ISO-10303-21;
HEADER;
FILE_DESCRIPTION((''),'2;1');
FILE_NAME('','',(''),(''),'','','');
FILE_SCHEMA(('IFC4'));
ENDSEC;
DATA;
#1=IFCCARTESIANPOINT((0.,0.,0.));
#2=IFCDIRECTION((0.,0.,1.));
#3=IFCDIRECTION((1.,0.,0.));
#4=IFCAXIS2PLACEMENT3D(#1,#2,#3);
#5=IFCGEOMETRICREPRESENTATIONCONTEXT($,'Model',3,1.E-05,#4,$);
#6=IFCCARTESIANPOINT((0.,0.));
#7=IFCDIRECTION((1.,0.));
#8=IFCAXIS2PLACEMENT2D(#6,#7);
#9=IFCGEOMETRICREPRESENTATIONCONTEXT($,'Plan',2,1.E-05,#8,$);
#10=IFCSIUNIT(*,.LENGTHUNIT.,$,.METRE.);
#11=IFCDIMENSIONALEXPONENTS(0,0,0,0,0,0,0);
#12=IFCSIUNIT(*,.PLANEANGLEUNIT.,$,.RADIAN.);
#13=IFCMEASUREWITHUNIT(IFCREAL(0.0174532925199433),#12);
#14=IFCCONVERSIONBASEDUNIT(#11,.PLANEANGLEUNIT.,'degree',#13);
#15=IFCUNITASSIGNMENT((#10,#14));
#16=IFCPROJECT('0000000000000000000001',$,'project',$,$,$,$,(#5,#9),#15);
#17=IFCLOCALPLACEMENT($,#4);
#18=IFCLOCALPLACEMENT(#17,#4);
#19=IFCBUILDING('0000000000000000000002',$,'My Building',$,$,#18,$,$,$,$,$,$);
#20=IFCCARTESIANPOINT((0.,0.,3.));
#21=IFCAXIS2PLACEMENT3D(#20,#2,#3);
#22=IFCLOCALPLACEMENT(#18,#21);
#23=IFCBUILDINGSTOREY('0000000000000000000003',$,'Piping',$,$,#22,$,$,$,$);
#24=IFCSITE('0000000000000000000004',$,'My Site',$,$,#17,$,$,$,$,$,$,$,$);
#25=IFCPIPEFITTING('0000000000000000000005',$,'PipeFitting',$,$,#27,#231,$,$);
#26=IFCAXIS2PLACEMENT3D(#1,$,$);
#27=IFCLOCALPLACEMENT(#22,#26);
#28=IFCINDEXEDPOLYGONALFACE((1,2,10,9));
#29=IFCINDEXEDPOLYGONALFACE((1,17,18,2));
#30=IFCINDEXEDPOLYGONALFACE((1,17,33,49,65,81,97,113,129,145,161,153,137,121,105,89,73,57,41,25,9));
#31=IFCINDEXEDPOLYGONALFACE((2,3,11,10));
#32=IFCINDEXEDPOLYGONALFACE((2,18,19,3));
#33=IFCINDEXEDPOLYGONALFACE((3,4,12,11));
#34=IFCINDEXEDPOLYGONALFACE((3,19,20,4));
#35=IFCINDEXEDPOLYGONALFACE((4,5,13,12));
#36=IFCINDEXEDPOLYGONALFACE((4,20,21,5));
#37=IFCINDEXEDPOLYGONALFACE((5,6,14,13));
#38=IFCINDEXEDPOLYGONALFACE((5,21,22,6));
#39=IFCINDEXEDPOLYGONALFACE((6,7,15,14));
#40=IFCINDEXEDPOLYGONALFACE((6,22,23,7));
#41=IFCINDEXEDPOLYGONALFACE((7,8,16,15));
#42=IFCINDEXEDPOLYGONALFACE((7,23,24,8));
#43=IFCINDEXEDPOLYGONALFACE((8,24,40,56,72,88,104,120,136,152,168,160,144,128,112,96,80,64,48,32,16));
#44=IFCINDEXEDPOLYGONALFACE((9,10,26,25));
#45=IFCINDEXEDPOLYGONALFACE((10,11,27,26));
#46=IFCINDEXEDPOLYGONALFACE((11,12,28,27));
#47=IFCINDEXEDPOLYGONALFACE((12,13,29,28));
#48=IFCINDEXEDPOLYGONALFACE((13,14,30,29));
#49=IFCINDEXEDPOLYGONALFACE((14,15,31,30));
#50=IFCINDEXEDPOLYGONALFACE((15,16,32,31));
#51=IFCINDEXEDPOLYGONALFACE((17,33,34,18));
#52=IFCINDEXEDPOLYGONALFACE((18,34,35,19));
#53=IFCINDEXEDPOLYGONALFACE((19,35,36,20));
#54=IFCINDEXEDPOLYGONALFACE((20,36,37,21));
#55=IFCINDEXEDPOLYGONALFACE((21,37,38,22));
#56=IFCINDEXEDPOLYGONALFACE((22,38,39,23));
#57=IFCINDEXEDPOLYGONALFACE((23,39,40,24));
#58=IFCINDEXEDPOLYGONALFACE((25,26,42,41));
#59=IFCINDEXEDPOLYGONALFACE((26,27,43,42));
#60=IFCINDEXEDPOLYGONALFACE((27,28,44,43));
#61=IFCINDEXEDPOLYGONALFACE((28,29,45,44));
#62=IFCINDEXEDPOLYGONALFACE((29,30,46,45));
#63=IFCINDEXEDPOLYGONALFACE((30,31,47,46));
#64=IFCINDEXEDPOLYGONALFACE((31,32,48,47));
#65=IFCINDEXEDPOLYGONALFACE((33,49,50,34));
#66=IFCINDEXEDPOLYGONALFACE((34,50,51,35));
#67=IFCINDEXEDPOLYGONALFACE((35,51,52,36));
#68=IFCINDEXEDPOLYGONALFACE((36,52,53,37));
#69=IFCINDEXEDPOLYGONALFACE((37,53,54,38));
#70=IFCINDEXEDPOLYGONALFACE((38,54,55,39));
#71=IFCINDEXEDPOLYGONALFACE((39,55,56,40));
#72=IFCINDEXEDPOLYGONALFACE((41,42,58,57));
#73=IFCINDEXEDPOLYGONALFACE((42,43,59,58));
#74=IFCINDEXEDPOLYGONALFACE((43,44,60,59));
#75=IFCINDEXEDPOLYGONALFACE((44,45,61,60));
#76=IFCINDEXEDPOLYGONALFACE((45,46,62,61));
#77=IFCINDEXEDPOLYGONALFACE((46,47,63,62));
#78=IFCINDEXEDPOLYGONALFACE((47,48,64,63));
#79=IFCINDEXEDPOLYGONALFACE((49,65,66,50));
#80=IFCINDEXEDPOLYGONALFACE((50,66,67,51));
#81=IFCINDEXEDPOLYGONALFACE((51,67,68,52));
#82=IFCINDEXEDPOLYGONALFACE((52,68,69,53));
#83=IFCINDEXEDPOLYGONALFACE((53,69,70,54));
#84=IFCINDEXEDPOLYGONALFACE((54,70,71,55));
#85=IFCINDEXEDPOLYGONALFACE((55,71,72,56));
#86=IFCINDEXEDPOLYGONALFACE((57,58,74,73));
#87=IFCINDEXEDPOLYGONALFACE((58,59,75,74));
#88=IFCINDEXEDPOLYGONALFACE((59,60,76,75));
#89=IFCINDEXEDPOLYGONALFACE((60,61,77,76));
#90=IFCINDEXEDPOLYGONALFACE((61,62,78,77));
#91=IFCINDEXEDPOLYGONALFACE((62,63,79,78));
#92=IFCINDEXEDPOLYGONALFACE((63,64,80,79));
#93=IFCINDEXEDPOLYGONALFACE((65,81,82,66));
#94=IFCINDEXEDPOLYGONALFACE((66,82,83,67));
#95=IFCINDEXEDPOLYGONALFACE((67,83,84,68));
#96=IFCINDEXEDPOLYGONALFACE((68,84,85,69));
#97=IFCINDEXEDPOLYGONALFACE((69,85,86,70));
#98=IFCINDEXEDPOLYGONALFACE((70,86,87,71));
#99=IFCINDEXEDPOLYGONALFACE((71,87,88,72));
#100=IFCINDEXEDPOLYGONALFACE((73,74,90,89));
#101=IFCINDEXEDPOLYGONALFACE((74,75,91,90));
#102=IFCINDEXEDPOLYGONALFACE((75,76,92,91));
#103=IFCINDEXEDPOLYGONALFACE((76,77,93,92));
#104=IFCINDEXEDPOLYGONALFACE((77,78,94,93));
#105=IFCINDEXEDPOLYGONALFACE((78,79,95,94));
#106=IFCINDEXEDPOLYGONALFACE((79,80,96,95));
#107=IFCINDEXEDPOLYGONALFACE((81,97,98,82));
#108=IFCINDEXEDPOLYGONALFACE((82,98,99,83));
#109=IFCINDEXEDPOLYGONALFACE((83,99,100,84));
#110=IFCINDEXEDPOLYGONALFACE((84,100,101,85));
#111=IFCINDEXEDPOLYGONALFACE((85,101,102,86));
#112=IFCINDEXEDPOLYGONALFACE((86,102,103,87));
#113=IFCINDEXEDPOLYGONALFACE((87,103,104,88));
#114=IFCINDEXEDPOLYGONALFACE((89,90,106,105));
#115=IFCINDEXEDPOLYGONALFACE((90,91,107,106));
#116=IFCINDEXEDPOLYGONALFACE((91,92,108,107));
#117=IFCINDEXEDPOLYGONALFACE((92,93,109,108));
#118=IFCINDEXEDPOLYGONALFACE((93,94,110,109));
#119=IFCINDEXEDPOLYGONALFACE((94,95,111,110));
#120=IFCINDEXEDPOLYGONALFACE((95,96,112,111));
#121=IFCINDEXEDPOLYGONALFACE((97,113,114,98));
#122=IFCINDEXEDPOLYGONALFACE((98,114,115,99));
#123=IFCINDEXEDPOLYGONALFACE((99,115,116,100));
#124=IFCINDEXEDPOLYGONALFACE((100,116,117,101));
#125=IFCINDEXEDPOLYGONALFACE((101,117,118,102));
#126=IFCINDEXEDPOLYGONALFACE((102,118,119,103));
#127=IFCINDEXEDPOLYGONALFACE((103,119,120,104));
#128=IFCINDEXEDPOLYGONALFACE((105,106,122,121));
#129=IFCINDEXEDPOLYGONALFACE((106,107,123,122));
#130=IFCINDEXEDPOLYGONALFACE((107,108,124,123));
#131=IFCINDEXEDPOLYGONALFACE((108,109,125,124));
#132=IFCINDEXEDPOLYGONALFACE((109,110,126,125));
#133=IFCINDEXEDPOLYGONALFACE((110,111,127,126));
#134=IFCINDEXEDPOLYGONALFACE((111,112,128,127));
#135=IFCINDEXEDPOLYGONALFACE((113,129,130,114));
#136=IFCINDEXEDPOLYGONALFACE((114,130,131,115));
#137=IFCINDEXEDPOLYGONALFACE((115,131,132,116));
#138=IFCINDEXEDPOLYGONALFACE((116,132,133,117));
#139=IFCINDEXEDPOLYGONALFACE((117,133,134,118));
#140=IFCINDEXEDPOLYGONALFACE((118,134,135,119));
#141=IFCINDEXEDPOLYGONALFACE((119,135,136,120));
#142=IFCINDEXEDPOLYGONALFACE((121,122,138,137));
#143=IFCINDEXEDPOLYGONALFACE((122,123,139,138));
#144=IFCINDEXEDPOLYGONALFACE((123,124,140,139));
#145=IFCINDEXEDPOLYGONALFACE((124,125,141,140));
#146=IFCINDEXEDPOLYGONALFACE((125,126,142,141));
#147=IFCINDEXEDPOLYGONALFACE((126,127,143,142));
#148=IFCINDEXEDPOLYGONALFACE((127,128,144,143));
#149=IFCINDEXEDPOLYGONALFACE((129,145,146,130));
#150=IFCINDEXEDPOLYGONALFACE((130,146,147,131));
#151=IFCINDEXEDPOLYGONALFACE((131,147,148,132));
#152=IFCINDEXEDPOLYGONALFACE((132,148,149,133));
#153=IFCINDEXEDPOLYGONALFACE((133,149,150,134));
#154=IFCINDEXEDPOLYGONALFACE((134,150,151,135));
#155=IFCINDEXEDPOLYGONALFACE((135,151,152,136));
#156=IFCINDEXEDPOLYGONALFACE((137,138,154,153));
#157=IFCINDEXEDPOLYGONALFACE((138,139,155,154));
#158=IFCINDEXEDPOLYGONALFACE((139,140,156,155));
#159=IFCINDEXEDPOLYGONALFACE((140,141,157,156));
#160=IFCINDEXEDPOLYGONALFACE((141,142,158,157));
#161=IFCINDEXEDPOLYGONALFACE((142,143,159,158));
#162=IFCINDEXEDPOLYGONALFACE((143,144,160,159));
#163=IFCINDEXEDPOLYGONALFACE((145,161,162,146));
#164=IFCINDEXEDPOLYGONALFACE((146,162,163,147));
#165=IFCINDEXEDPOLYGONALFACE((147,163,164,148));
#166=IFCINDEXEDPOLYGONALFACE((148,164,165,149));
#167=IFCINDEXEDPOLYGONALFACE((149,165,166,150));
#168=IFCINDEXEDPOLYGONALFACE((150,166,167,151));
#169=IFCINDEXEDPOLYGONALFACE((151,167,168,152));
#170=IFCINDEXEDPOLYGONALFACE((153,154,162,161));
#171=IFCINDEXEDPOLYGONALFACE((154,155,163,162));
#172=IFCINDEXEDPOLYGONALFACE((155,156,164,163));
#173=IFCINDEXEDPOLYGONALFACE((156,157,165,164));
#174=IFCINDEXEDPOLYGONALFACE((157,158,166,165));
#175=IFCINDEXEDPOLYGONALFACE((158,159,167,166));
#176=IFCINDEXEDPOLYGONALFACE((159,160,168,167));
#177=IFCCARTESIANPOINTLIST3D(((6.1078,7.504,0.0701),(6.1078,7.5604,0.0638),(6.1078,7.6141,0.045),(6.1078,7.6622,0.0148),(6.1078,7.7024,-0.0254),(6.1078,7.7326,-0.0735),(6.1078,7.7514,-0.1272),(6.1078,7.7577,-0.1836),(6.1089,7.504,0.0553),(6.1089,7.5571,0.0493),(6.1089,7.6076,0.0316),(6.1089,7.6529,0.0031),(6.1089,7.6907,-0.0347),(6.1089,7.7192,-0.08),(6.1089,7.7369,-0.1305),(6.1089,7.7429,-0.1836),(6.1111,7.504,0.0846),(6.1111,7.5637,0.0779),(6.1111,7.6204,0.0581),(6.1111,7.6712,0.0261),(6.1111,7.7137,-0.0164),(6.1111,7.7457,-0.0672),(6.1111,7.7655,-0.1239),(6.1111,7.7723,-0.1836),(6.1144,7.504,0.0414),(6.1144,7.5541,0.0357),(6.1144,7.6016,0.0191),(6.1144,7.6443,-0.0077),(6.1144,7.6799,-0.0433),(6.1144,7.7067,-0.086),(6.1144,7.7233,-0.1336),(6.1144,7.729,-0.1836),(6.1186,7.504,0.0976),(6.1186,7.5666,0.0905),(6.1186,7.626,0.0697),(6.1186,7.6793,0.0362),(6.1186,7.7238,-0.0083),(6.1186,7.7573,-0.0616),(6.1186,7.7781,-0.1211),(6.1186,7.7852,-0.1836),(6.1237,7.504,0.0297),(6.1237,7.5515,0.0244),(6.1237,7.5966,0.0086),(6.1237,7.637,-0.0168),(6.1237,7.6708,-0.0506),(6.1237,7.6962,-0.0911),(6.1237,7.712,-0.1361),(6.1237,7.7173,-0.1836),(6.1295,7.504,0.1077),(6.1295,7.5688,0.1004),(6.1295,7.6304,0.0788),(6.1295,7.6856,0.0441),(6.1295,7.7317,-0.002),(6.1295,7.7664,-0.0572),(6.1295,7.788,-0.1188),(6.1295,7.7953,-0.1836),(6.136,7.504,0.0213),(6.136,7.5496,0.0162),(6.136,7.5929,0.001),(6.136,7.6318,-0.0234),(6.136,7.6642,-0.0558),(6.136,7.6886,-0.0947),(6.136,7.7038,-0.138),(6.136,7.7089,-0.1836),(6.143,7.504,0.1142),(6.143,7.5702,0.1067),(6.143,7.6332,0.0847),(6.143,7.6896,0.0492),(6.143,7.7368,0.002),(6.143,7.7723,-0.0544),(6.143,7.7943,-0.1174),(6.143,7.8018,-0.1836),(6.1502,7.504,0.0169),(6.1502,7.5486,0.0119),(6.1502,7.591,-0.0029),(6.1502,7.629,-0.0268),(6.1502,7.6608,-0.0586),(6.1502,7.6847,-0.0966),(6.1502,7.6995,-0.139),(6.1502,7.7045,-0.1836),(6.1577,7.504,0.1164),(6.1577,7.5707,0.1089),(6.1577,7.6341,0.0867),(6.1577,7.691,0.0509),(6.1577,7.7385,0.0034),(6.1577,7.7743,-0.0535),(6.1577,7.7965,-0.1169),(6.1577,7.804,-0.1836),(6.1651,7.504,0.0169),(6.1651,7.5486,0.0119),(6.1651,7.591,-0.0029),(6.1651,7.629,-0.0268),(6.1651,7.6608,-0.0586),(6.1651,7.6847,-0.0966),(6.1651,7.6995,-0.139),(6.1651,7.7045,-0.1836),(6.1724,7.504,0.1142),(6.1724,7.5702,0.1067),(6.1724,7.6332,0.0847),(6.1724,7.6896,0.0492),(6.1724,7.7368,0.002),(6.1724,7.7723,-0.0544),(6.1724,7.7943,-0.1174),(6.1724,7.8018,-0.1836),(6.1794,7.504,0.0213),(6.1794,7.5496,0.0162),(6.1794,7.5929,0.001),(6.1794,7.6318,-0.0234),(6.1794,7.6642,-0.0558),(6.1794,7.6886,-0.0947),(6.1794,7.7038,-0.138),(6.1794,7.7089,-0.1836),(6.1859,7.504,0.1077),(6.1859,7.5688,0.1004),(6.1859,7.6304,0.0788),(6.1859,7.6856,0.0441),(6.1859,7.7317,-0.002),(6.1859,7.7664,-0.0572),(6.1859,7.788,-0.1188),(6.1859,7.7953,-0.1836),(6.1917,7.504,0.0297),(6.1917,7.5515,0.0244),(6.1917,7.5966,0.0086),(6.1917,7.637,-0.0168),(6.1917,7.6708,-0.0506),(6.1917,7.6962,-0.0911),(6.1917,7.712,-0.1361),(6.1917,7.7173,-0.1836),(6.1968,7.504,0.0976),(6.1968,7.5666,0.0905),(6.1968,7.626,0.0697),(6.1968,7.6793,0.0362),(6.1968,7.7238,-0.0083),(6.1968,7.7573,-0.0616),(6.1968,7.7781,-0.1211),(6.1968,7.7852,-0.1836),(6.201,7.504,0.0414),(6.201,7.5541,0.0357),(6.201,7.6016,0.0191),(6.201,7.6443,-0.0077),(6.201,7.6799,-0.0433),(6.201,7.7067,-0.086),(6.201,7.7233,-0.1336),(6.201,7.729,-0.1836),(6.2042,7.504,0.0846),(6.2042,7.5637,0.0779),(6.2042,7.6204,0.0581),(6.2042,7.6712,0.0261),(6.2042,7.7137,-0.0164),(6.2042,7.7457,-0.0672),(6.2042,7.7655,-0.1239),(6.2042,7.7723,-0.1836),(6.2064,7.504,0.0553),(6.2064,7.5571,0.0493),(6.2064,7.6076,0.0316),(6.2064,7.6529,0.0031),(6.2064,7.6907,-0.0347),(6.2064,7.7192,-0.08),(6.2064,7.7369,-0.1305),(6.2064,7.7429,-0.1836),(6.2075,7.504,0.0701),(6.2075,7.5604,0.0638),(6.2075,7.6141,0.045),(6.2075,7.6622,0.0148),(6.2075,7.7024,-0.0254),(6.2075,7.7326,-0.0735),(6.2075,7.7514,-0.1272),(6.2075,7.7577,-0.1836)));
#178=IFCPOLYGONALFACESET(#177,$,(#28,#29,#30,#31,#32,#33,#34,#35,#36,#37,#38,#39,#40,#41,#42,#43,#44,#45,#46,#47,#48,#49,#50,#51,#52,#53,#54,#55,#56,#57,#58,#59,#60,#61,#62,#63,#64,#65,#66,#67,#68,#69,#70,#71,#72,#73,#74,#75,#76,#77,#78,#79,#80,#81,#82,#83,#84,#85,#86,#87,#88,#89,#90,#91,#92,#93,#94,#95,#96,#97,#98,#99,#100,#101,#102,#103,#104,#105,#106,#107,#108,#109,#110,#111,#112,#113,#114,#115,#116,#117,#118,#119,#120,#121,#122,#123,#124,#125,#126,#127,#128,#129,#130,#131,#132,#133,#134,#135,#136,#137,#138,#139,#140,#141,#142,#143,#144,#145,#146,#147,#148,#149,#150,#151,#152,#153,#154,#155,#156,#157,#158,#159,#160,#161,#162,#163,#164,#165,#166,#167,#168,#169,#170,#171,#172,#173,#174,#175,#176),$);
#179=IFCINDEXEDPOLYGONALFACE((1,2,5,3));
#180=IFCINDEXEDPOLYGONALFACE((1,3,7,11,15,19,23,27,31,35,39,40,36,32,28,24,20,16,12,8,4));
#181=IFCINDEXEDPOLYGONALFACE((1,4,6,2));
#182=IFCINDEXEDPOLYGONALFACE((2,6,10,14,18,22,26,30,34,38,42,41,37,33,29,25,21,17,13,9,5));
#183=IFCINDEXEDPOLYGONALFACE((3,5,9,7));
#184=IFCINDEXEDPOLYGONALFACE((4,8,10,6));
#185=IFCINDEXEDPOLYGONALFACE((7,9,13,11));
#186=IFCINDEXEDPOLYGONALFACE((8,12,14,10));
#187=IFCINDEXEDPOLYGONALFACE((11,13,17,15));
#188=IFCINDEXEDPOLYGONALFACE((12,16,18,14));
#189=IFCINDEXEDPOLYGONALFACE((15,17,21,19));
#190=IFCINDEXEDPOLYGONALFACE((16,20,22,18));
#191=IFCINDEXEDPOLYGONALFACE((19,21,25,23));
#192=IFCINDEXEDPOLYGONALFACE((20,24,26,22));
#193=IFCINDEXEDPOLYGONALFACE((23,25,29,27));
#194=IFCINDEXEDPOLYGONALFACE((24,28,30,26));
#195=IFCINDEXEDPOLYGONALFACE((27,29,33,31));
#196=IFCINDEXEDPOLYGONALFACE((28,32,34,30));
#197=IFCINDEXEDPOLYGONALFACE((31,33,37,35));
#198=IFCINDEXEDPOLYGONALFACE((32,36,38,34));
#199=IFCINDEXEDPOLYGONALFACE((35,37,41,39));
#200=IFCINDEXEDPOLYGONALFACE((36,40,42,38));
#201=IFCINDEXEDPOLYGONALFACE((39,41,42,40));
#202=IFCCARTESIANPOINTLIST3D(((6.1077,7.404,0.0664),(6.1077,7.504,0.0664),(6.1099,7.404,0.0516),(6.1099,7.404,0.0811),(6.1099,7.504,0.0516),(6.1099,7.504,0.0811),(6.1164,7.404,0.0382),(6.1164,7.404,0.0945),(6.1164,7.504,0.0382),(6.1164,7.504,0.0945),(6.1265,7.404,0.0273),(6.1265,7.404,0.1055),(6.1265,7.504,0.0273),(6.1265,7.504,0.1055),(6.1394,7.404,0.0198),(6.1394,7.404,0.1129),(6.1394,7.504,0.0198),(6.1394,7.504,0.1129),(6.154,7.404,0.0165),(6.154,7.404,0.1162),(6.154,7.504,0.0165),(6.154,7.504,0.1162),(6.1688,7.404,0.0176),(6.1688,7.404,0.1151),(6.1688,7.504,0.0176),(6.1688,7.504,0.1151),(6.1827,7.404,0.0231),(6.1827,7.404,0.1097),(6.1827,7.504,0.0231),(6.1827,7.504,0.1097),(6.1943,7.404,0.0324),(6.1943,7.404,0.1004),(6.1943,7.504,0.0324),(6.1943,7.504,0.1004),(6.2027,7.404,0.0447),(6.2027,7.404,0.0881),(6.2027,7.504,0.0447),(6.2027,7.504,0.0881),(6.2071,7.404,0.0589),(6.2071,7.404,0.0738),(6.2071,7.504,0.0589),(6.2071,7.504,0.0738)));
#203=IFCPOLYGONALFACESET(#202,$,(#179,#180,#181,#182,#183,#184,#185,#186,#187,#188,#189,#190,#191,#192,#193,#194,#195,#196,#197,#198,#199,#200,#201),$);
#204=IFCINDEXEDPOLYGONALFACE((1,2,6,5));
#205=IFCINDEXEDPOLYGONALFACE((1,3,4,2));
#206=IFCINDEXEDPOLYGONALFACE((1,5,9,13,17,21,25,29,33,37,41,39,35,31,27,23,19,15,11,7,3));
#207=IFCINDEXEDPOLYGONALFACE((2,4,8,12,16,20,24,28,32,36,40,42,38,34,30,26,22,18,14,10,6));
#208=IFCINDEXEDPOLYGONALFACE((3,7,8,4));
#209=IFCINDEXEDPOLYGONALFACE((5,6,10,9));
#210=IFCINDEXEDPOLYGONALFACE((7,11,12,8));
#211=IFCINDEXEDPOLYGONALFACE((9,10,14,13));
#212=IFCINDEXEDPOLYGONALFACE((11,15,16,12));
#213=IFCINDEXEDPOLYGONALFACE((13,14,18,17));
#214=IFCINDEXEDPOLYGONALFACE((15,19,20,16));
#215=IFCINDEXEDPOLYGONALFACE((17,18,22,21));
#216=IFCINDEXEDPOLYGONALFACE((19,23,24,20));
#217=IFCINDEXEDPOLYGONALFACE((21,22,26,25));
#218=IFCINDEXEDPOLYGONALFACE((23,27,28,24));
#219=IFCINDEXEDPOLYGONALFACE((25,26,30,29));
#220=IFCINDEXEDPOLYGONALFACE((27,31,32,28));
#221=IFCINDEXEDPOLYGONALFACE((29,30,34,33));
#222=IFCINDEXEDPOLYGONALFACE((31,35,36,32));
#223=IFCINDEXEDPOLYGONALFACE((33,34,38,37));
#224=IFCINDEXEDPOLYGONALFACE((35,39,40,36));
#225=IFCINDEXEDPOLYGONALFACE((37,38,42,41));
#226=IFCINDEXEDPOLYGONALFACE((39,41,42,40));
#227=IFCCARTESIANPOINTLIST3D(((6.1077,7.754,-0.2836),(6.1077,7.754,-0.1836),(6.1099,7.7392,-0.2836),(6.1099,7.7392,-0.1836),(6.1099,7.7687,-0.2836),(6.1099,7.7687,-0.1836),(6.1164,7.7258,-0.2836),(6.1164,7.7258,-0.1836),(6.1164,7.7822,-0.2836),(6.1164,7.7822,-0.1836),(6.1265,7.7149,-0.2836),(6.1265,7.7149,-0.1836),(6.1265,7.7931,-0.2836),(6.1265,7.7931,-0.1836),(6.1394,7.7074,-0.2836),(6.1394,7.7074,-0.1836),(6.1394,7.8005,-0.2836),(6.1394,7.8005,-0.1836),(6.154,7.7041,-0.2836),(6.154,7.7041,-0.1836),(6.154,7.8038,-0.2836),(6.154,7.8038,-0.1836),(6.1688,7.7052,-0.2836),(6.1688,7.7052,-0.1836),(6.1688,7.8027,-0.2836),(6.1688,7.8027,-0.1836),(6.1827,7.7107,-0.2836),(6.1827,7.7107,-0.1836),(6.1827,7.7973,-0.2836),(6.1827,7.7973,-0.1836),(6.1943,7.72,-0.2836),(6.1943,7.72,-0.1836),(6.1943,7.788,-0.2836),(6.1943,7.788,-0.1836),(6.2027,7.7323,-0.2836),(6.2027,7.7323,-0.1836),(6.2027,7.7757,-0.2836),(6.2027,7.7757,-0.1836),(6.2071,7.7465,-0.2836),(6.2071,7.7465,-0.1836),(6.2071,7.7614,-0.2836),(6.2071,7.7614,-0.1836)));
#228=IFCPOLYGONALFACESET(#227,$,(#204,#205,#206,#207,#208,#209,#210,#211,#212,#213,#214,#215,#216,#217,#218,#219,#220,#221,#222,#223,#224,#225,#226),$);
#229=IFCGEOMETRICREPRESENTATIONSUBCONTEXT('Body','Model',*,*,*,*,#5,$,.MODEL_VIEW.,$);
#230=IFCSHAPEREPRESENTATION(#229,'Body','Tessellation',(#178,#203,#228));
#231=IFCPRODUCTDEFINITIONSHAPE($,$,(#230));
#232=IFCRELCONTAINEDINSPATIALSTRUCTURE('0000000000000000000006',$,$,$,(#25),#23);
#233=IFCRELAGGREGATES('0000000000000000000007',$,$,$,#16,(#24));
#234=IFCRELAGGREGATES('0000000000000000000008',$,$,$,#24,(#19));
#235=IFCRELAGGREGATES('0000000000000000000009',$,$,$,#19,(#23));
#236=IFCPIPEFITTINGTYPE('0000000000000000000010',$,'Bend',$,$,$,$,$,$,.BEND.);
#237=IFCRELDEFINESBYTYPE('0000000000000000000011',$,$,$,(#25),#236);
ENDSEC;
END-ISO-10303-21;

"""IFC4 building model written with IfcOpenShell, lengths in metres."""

from ifc_helpers import new_model, entity, si_unit, converted_unit, frame, origin_with_axes, origin_2d_with_axis, place, context, subcontext, project, spatial, circle, extrude, source, transform, mapped, type_object, type_shapes, element, save


model = new_model("IFC4")

# Units and contexts
model_context = context("Model", 3, precision=1e-05, world=origin_with_axes())
plan_context = context("Plan", 2, precision=1e-05, world=origin_2d_with_axis())
body_context = subcontext(model_context, "Body", "Model", "MODEL_VIEW")
ifc_project = project(units=[si_unit("LENGTHUNIT", "METRE"), converted_unit("PLANEANGLEUNIT", "degree", entity("IfcReal", 0.0174532925199433), si_unit("PLANEANGLEUNIT", "RADIAN"), dimensions=[0, 0, 0, 0, 0, 0, 0])], contexts=[model_context, plan_context])

# Site, building, storey
site_placement = place(None, origin_with_axes())
site = spatial("IfcSite", under=ifc_project, at=site_placement, Name="My Site")
building_placement = place(site_placement, origin_with_axes())
building = spatial("IfcBuilding", under=site, at=building_placement, Name="My Building")
storey_placement = place(building_placement, frame((0.0, 0.0, 3.0), z_axis=(0.0, 0.0, 1.0), x_axis=(1.0, 0.0, 0.0)))
storey = spatial("IfcBuildingStorey", under=building, at=storey_placement, Name="Piping")

# Pipe fitting
pipe_fitting_type_1 = type_object("IfcPipeFittingType", Name="Bend", PredefinedType="BEND")
shared_shape = source(origin_with_axes(), body_context, "Body", "SolidModel", [
    entity("IfcSweptDiskSolid", entity("IfcIndexedPolyCurve", entity("IfcCartesianPointList3D", [[0.0, 0.0, 0.1], [0.0, -0.0732, 0.2768], [0.0, -0.25, 0.35]]), [entity("IfcArcIndex", [1, 2, 3])]), 0.05),
    extrude(circle(Radius=0.05), origin_with_axes(), (0.0, 0.0, 1.0), 0.1),
    extrude(circle(Radius=0.05), frame((0.0, -0.25, 0.35), z_axis=(0.0, -1.0, -0.000002), x_axis=(1.0, 0.0, 0.0)), (0.0, 0.0, 1.0), 0.1),
])
type_shapes(pipe_fitting_type_1, [shared_shape])
for number, where, z_axis, x_axis, name in (
    (1, (6.1577, 7.404, 0.0664), (0.0, 1.0, 0.000002), (-1.0, 0.0, 0.0), "PipeFitting"),
):
    element("IfcPipeFitting", number, at=place(storey_placement, frame(where, z_axis=z_axis, x_axis=x_axis)), inside=storey, type_object=pipe_fitting_type_1, Name=name, context=body_context, shape_type="MappedRepresentation", body=[
        mapped(shared_shape, transform((0.0, 0.0, 0.0), x_axis=(1.0, 0.0, 0.0), y_axis=(0.0, 1.0, 0.0), z_axis=(0.0, 0.0, 1.0), scale=1.0)),
    ])

save(model, "model.ifc")
